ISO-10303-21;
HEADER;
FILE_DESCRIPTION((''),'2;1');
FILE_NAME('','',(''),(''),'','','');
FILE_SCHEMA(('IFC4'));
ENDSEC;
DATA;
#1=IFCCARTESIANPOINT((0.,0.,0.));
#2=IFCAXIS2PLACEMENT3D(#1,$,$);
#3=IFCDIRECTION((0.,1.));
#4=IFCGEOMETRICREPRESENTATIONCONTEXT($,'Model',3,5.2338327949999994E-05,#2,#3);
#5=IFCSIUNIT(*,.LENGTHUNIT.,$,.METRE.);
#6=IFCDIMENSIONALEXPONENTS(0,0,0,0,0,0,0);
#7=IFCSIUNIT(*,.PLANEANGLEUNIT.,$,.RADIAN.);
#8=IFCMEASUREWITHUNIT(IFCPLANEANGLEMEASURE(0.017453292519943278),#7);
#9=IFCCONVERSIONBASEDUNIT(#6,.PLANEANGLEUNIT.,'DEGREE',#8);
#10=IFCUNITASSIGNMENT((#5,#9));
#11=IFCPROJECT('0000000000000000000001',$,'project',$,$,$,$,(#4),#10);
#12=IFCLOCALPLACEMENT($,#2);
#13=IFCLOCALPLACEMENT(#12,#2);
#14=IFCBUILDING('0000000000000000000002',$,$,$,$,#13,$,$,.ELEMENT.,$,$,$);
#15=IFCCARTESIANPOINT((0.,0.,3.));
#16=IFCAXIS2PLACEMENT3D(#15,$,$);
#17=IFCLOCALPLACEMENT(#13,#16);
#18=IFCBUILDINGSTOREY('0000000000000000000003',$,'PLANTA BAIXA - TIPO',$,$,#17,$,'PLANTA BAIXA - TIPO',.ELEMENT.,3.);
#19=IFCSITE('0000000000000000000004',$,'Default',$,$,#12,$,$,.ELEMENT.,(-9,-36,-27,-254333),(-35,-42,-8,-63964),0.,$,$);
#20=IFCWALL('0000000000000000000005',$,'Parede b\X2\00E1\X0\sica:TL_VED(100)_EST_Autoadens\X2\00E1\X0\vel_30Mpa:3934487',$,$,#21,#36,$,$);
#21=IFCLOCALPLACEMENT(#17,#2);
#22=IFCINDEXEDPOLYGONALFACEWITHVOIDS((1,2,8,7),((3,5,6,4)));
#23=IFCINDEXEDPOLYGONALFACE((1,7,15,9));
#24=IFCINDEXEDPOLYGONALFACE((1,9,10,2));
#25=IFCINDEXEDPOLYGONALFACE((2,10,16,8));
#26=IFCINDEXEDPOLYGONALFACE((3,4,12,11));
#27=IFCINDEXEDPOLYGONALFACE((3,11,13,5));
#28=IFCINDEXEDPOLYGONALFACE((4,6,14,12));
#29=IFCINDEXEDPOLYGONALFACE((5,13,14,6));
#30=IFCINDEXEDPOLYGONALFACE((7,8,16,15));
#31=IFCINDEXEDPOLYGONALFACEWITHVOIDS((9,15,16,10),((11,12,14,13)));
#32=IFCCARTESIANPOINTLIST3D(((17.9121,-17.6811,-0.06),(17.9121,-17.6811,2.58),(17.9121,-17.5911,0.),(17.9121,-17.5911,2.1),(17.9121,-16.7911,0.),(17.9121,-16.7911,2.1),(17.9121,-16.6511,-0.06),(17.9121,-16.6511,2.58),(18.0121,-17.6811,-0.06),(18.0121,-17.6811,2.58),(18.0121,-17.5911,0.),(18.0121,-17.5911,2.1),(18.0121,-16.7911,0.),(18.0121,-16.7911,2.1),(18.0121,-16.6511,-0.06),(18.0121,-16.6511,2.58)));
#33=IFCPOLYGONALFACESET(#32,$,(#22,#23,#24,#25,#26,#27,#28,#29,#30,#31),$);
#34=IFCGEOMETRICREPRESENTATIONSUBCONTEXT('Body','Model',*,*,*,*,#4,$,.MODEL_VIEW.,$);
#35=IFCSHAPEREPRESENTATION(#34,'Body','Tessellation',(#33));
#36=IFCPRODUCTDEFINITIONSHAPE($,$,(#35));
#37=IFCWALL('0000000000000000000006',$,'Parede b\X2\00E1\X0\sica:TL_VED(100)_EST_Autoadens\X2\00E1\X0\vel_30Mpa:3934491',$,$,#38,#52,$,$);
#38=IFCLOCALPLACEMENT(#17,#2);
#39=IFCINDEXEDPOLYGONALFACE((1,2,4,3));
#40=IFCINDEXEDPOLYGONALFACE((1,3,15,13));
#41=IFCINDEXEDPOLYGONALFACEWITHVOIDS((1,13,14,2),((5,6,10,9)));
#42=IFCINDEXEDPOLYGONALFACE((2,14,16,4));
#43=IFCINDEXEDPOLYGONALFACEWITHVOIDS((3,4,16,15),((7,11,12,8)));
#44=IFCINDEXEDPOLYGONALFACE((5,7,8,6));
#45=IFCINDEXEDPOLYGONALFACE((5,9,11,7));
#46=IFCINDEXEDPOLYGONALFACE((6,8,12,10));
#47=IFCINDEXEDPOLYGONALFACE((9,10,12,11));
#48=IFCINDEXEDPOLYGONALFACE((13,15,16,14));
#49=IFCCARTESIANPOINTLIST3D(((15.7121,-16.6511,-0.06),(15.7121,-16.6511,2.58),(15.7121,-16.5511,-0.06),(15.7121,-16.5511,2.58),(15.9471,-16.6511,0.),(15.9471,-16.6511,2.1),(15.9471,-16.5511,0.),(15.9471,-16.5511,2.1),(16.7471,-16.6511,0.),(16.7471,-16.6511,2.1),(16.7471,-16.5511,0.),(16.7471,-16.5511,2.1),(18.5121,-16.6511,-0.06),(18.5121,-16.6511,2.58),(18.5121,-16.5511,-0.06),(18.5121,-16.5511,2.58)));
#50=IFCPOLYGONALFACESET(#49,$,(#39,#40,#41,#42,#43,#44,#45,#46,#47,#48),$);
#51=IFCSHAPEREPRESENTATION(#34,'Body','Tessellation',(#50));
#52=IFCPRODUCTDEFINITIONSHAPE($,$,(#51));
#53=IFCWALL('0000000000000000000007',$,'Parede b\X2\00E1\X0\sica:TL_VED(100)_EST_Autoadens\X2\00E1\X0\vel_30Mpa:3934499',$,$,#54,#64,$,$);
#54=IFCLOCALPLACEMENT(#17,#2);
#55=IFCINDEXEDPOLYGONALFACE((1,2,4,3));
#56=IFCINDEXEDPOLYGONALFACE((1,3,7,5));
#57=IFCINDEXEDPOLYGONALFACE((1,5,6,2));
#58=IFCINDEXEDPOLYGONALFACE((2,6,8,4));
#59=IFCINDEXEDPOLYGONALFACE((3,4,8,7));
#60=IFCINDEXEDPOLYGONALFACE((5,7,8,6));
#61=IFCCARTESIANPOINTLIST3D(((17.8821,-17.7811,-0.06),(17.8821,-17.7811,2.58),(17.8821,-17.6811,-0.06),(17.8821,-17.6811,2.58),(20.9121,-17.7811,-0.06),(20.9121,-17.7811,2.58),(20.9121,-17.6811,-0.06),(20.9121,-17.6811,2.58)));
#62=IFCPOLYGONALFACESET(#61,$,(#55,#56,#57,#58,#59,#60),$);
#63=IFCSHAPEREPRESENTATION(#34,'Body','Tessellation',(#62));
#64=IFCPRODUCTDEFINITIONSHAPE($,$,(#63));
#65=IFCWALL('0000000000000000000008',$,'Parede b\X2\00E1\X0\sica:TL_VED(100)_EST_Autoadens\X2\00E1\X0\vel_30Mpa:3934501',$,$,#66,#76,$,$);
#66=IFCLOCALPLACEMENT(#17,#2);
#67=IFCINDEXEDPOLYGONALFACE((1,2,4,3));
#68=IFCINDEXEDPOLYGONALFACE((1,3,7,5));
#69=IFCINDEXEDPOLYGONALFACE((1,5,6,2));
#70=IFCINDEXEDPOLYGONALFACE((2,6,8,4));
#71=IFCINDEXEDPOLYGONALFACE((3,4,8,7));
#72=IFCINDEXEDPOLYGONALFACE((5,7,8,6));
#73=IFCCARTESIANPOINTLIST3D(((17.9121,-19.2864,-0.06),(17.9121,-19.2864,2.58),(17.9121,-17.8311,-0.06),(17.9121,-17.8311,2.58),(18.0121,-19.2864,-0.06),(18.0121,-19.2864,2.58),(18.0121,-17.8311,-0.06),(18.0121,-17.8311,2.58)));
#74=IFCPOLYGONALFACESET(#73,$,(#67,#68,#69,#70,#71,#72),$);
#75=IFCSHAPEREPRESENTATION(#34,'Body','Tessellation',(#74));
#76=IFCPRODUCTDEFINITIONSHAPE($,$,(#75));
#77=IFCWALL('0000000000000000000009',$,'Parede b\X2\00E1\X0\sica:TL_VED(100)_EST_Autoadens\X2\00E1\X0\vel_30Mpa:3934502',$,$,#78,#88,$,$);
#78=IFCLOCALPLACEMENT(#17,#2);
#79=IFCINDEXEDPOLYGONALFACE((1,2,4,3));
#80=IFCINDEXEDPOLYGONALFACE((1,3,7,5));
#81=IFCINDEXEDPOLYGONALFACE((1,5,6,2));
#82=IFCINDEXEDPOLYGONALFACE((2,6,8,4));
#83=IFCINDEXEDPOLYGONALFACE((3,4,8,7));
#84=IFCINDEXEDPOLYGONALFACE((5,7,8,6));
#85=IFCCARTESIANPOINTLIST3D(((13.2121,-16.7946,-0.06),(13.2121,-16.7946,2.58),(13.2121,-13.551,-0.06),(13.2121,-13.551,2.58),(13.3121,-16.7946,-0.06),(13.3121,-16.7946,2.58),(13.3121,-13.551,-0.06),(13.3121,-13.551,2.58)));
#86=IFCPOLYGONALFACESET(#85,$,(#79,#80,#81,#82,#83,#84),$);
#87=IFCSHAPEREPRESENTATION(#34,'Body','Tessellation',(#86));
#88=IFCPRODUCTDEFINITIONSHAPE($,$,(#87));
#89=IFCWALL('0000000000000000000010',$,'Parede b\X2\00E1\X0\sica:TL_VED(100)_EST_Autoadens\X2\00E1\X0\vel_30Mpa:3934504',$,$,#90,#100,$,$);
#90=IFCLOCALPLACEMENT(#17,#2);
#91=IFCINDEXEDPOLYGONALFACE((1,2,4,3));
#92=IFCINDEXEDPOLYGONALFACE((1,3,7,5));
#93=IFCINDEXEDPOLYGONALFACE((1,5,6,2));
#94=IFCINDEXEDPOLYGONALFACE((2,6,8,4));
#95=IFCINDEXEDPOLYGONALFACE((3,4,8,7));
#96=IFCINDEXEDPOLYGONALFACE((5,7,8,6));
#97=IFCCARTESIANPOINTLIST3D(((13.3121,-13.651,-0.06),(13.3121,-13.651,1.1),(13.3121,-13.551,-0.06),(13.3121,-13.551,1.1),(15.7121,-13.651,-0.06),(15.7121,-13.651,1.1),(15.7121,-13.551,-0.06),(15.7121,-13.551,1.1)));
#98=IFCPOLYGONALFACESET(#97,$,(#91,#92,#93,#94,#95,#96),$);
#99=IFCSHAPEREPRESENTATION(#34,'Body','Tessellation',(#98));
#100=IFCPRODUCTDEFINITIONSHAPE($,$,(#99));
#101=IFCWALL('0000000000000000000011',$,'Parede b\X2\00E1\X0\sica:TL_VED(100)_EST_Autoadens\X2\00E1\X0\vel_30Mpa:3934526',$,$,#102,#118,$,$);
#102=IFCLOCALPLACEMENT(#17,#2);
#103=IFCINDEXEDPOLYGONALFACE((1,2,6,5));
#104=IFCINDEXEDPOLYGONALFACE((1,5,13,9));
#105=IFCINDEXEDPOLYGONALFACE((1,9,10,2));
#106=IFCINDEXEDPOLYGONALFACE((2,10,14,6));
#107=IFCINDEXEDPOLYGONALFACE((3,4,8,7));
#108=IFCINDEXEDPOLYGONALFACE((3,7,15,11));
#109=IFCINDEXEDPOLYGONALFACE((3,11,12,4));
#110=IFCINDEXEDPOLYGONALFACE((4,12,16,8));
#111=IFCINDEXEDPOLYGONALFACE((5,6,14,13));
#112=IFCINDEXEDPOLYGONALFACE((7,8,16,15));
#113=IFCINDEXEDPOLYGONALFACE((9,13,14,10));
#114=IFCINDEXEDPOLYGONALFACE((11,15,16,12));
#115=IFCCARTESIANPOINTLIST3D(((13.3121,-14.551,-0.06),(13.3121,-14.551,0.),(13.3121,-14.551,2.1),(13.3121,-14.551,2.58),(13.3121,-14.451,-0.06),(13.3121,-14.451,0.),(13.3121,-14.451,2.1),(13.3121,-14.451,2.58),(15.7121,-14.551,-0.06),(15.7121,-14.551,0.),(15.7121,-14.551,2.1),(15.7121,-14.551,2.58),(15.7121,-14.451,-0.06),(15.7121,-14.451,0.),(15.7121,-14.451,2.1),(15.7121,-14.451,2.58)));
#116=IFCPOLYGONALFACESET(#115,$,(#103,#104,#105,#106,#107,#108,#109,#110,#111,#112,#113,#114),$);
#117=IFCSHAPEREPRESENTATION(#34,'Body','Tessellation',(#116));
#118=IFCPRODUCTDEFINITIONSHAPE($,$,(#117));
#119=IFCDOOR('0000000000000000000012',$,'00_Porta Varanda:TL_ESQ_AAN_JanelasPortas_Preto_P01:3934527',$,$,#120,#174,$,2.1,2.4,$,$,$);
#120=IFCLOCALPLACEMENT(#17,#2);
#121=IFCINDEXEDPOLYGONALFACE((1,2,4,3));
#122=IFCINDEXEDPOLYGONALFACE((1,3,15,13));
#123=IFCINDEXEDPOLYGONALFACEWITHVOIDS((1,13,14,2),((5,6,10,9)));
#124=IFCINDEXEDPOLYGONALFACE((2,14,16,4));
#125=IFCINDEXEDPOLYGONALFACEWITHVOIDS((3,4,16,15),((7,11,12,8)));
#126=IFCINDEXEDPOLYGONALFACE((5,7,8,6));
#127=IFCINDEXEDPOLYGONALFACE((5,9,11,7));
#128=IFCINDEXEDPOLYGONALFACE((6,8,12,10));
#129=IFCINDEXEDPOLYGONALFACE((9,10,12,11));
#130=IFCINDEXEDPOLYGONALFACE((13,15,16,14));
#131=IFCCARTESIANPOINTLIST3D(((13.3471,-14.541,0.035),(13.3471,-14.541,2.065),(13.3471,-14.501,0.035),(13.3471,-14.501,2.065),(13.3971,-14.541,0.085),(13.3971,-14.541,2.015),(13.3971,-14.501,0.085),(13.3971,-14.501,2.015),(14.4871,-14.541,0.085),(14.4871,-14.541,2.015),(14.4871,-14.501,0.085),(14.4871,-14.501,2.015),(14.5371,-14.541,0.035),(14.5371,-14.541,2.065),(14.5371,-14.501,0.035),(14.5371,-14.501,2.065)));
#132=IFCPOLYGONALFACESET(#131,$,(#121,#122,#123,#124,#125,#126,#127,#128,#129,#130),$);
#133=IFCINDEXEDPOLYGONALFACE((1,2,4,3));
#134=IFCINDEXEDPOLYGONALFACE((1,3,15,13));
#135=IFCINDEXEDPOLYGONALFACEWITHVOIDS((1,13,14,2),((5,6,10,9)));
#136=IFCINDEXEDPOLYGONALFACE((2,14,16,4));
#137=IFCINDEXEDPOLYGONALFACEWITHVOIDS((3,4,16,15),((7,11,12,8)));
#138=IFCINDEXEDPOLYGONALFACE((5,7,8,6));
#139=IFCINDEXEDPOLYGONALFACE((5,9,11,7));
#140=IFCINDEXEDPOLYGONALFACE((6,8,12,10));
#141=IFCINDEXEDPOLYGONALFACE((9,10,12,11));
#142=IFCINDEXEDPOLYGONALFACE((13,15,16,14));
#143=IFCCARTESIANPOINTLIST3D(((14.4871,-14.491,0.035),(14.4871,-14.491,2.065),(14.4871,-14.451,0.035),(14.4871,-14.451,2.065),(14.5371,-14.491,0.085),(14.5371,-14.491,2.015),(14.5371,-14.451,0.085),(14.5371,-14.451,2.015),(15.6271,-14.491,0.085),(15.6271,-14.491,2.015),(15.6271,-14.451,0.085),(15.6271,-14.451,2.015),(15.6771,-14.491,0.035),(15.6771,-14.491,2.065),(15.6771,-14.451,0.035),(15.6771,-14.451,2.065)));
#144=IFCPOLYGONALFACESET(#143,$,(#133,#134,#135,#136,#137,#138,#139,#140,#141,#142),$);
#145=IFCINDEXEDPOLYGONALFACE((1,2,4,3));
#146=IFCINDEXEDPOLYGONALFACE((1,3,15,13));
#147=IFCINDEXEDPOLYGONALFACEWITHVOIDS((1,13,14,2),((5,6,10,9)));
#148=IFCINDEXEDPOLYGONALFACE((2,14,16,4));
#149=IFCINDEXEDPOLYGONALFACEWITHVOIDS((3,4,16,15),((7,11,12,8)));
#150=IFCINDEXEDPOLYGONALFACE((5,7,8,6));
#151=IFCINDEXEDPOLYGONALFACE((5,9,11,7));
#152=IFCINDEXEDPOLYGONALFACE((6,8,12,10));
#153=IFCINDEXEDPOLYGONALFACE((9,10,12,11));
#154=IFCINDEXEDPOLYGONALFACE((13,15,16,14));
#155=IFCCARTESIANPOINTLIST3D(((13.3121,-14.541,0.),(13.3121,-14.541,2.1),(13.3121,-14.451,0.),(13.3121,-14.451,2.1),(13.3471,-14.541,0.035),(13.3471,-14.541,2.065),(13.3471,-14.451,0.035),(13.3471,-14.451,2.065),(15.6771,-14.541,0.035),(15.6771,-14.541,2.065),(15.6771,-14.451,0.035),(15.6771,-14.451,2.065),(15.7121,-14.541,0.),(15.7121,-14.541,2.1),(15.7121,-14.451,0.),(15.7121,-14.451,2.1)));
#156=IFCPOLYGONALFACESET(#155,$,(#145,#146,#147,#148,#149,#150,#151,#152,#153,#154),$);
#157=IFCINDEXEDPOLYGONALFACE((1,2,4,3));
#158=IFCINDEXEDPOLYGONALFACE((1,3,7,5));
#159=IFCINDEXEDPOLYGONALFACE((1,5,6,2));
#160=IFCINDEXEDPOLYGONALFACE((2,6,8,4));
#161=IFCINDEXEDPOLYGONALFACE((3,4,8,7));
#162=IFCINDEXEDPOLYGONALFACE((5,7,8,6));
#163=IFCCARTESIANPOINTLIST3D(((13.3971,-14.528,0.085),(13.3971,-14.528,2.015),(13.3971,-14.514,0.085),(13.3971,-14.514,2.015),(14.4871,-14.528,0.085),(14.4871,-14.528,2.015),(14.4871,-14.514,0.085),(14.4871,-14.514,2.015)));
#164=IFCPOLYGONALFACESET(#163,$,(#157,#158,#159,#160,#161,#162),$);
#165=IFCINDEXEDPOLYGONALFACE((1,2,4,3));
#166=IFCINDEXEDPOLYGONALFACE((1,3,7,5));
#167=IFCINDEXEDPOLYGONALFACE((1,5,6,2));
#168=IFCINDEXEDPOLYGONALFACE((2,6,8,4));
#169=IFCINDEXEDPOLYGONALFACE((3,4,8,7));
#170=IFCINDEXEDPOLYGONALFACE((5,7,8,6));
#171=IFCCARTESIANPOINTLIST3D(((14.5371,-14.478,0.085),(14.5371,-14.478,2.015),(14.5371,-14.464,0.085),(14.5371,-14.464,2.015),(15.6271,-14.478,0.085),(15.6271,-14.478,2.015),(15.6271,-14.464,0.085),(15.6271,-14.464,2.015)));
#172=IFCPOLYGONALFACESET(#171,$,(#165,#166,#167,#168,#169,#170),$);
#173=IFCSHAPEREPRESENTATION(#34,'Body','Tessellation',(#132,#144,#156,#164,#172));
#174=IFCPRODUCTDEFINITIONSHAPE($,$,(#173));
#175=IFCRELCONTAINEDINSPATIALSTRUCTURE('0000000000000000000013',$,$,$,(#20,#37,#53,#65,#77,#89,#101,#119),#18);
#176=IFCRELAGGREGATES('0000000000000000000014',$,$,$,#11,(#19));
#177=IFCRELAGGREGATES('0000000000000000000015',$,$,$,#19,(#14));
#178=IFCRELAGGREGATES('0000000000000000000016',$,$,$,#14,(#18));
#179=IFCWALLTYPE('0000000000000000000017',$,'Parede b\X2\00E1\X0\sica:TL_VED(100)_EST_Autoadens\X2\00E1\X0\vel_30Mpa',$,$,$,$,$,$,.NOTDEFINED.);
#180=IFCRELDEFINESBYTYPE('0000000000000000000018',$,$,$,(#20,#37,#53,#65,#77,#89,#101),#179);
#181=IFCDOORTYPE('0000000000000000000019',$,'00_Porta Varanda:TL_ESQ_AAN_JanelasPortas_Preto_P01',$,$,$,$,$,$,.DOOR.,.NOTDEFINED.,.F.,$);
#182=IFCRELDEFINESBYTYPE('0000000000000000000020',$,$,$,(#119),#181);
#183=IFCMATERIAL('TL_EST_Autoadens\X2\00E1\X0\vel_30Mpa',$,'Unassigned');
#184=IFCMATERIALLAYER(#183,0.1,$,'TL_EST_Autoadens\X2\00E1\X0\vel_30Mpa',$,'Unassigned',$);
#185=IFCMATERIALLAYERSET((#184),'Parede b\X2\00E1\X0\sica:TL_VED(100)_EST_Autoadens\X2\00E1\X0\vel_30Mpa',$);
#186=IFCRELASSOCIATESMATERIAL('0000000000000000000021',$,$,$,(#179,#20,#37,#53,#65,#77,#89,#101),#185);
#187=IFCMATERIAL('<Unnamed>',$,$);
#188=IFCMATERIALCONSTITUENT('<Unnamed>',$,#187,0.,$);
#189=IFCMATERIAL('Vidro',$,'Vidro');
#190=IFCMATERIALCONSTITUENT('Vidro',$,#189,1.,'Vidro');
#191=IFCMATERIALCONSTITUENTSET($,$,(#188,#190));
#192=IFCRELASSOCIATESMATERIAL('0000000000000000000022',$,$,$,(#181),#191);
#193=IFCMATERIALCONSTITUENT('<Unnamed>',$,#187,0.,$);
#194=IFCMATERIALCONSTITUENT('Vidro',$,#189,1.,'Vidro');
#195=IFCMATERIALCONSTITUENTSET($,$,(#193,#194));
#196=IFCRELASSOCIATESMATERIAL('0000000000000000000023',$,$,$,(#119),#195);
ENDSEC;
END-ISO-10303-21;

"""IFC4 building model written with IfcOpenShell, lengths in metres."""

from ifc_helpers import new_model, entity, si_unit, converted_unit, direction, frame, frame_2d, origin, place, context, subcontext, project, spatial, polyline, rectangle, outline, extrude, source, transform, mapped, material, layer, layer_set, layer_usage, constituent, constituent_set, type_object, type_shapes, element, fill, save


model = new_model("IFC4")

# Units and contexts
model_context = context("Model", 3, precision=5.2338327949999994e-05, world=origin(), true_north=direction((0.0, 1.0)))
body_context = subcontext(model_context, "Body", "Model", "MODEL_VIEW")
ifc_project = project(units=[si_unit("LENGTHUNIT", "METRE"), converted_unit("PLANEANGLEUNIT", "DEGREE", entity("IfcPlaneAngleMeasure", 0.017453292519943278), si_unit("PLANEANGLEUNIT", "RADIAN"), dimensions=[0, 0, 0, 0, 0, 0, 0])], contexts=[model_context])

# Site, building, storey
site_placement = place(None, frame((0.0, 0.0, 0.0)))
site = spatial("IfcSite", under=ifc_project, at=site_placement, Name="Default", CompositionType="ELEMENT", RefLatitude=(-9, -36, -27, -254333), RefLongitude=(-35, -42, -8, -63964), RefElevation=0.0)
building_placement = place(site_placement, origin())
building = spatial("IfcBuilding", under=site, at=building_placement, CompositionType="ELEMENT")
storey_placement = place(building_placement, frame((0.0, 0.0, 3.0)))
storey = spatial("IfcBuildingStorey", under=building, at=storey_placement, Name="PLANTA BAIXA - TIPO", LongName="PLANTA BAIXA - TIPO", CompositionType="ELEMENT", Elevation=3.0)

# Walls, openings
ifc_material_1 = material(Name="TL_EST_Autoadensável_30Mpa", Category="Unassigned")
ifc_layer_1 = layer(ifc_material_1, 0.1, Name="TL_EST_Autoadensável_30Mpa", Category="Unassigned")
ifc_layer_set_1 = layer_set([ifc_layer_1], Name="Parede básica:TL_VED(100)_EST_Autoadensável_30Mpa")
ifc_layer_usage_1 = layer_usage(ifc_layer_set_1, "AXIS2", "NEGATIVE", 0.05)
wall_type_1 = type_object("IfcWallType", Name="Parede básica:TL_VED(100)_EST_Autoadensável_30Mpa", PredefinedType="NOTDEFINED", material=ifc_layer_set_1)
wall_1_placement = place(storey_placement, frame((17.9621, -16.6511, -0.06), z_axis=(0.0, 0.0, 1.0), x_axis=(0.0, -1.0, 0.0)))
wall_1 = element("IfcWall", 1, at=wall_1_placement, inside=storey, type_object=wall_type_1, material=ifc_layer_usage_1, Name="Parede básica:TL_VED(100)_EST_Autoadensável_30Mpa:3934487", context=body_context, shape_type="SweptSolid", body=[
    extrude(rectangle(XDim=1.03, YDim=0.1, at=frame_2d((0.515, 0.0), x_axis=(-1.0, 0.0))), origin(), (0.0, 0.0, 1.0), 2.64),
])
opening_1_placement = place(wall_1_placement, frame((0.14, -0.05, 0.06)))
element("IfcOpeningElement", 2, at=opening_1_placement, cuts=wall_1, PredefinedType="OPENING", context=body_context, shape_type="SweptSolid", body=[
    extrude(rectangle(XDim=2.1, YDim=0.8, at=frame_2d((1.05, 0.4), x_axis=(1.0, 0.0))), frame((0.0, 0.0, 0.0), z_axis=(0.0, 1.0, 0.0), x_axis=(0.0, 0.0, 1.0)), (0.0, 0.0, 1.0), 0.1),
])
ifc_layer_usage_2 = layer_usage(ifc_layer_set_1, "AXIS2", "NEGATIVE", 0.05)
wall_2_placement = place(storey_placement, frame((15.7121, -16.6011, -0.06)))
wall_2 = element("IfcWall", 3, at=wall_2_placement, inside=storey, type_object=wall_type_1, material=ifc_layer_usage_2, Name="Parede básica:TL_VED(100)_EST_Autoadensável_30Mpa:3934491", context=body_context, shape_type="SweptSolid", body=[
    extrude(rectangle(XDim=2.8, YDim=0.1, at=frame_2d((1.4, 0.0), x_axis=(-1.0, 0.0))), origin(), (0.0, 0.0, 1.0), 2.64),
])
opening_2_placement = place(wall_2_placement, frame((0.235, -0.05, 0.06)))
element("IfcOpeningElement", 4, at=opening_2_placement, cuts=wall_2, PredefinedType="OPENING", context=body_context, shape_type="SweptSolid", body=[
    extrude(rectangle(XDim=2.1, YDim=0.8, at=frame_2d((1.05, 0.4), x_axis=(1.0, 0.0))), frame((0.0, 0.0, 0.0), z_axis=(0.0, 1.0, 0.0), x_axis=(0.0, 0.0, 1.0)), (0.0, 0.0, 1.0), 0.1),
])

# Walls
ifc_layer_usage_3 = layer_usage(ifc_layer_set_1, "AXIS2", "POSITIVE", -0.05)
wall_3_placement = place(storey_placement, frame((17.8821, -17.7311, -0.06)))
element("IfcWall", 5, at=wall_3_placement, inside=storey, type_object=wall_type_1, material=ifc_layer_usage_3, Name="Parede básica:TL_VED(100)_EST_Autoadensável_30Mpa:3934499", context=body_context, shape_type="SweptSolid", body=[
    extrude(rectangle(XDim=3.03, YDim=0.1, at=frame_2d((1.515, 0.0), x_axis=(-1.0, 0.0))), origin(), (0.0, 0.0, 1.0), 2.64),
])
ifc_layer_usage_4 = layer_usage(ifc_layer_set_1, "AXIS2", "NEGATIVE", 0.05)
wall_4_placement = place(storey_placement, frame((17.9621, -19.2864, -0.06), z_axis=(0.0, 0.0, 1.0), x_axis=(0.0, 1.0, 0.0)))
element("IfcWall", 6, at=wall_4_placement, inside=storey, type_object=wall_type_1, material=ifc_layer_usage_4, Name="Parede básica:TL_VED(100)_EST_Autoadensável_30Mpa:3934501", context=body_context, shape_type="SweptSolid", body=[
    extrude(rectangle(XDim=1.4552, YDim=0.1, at=frame_2d((0.7276, 0.0), x_axis=(-1.0, 0.0))), origin(), (0.0, 0.0, 1.0), 2.64),
])
ifc_layer_usage_5 = layer_usage(ifc_layer_set_1, "AXIS2", "POSITIVE", -0.05)
wall_5_placement = place(storey_placement, frame((13.2621, -13.551, -0.06), z_axis=(0.0, 0.0, 1.0), x_axis=(0.0, -1.0, 0.0)))
element("IfcWall", 7, at=wall_5_placement, inside=storey, type_object=wall_type_1, material=ifc_layer_usage_5, Name="Parede básica:TL_VED(100)_EST_Autoadensável_30Mpa:3934502", context=body_context, shape_type="SweptSolid", body=[
    extrude(rectangle(XDim=3.2437, YDim=0.1, at=frame_2d((1.6218, 0.0), x_axis=(-1.0, 0.0))), origin(), (0.0, 0.0, 1.0), 2.64),
])

# Wall
ifc_layer_usage_6 = layer_usage(ifc_layer_set_1, "AXIS2", "POSITIVE", -0.05)
wall_6_placement = place(storey_placement, frame((15.7121, -13.601, -0.06), z_axis=(0.0, 0.0, 1.0), x_axis=(-1.0, 0.0, 0.0)))
element("IfcWall", 8, at=wall_6_placement, inside=storey, type_object=wall_type_1, material=ifc_layer_usage_6, Name="Parede básica:TL_VED(100)_EST_Autoadensável_30Mpa:3934504", context=body_context, shape_type="SweptSolid", body=[
    extrude(rectangle(XDim=2.4, YDim=0.1, at=frame_2d((1.2, 0.0), x_axis=(-1.0, 0.0))), origin(), (0.0, 0.0, 1.0), 1.16),
])

# Wall, opening, door
ifc_layer_usage_7 = layer_usage(ifc_layer_set_1, "AXIS2", "POSITIVE", -0.05)
wall_7_placement = place(storey_placement, frame((15.7121, -14.501, -0.06), z_axis=(0.0, 0.0, 1.0), x_axis=(-1.0, 0.0, 0.0)))
wall_7 = element("IfcWall", 9, at=wall_7_placement, inside=storey, type_object=wall_type_1, material=ifc_layer_usage_7, Name="Parede básica:TL_VED(100)_EST_Autoadensável_30Mpa:3934526", context=body_context, shape_type="SweptSolid", body=[
    extrude(rectangle(XDim=2.4, YDim=0.1, at=frame_2d((1.2, 0.0), x_axis=(-1.0, 0.0))), origin(), (0.0, 0.0, 1.0), 2.64),
])
opening_3_placement = place(wall_7_placement, frame((0.0, -0.05, 0.06)))
opening_3 = element("IfcOpeningElement", 10, at=opening_3_placement, cuts=wall_7, PredefinedType="OPENING", context=body_context, shape_type="SweptSolid", body=[
    extrude(rectangle(XDim=2.1, YDim=2.4, at=frame_2d((1.05, 1.2), x_axis=(1.0, 0.0))), frame((0.0, 0.0, 0.0), z_axis=(0.0, 1.0, 0.0), x_axis=(0.0, 0.0, 1.0)), (0.0, 0.0, 1.0), 0.1),
])
ifc_material_2 = material(Name="<Unnamed>")
ifc_constituent_1 = constituent(ifc_material_2, Name="<Unnamed>", fraction=0.0)
ifc_material_3 = material(Name="Vidro", Category="Vidro")
ifc_constituent_2 = constituent(ifc_material_3, Name="Vidro", Category="Vidro", fraction=1.0)
ifc_constituent_set_1 = constituent_set(constituents=[ifc_constituent_1, ifc_constituent_2])
ifc_constituent_3 = constituent(ifc_material_2, Name="<Unnamed>", fraction=0.0)
ifc_constituent_4 = constituent(ifc_material_3, Name="Vidro", Category="Vidro", fraction=1.0)
ifc_constituent_set_2 = constituent_set(constituents=[ifc_constituent_3, ifc_constituent_4])
door_type = type_object("IfcDoorType", Name="00_Porta Varanda:TL_ESQ_AAN_JanelasPortas_Preto_P01", OperationType="NOTDEFINED", ParameterTakesPrecedence=False, PredefinedType="DOOR", material=ifc_constituent_set_2)
shared_shape = source(origin(), body_context, "Body", "SweptSolid", [
    extrude(outline(polyline([(-1.015, -0.595), (1.015, -0.595), (1.015, 0.595), (-1.015, 0.595), (-1.015, -0.595)]), holes=[polyline([(0.965, -0.545), (-0.965, -0.545), (-0.965, 0.545), (0.965, 0.545), (0.965, -0.545)])]), frame((1.77, 0.05, 1.05), z_axis=(0.0, 1.0, 0.0), x_axis=(0.0, 0.0, 1.0)), (0.0, 0.0, 1.0), 0.04),
    extrude(outline(polyline([(-1.015, -0.595), (1.015, -0.595), (1.015, 0.595), (-1.015, 0.595), (-1.015, -0.595)]), holes=[polyline([(0.965, -0.545), (-0.965, -0.545), (-0.965, 0.545), (0.965, 0.545), (0.965, -0.545)])]), frame((0.63, 0.0, 1.05), z_axis=(0.0, 1.0, 0.0), x_axis=(0.0, 0.0, -1.0)), (0.0, 0.0, 1.0), 0.04),
    extrude(outline(polyline([(-1.05, -1.2), (1.05, -1.2), (1.05, 1.2), (-1.05, 1.2), (-1.05, -1.2)]), holes=[polyline([(1.015, -1.165), (-1.015, -1.165), (-1.015, 1.165), (1.015, 1.165), (1.015, -1.165)])]), frame((1.2, 0.0, 1.05), z_axis=(0.0, 1.0, 0.0), x_axis=(0.0, 0.0, -1.0)), (0.0, 0.0, 1.0), 0.09),
    extrude(rectangle(XDim=0.014, YDim=1.09, at=frame_2d((0.0, 0.0), x_axis=(1.0, 0.0))), frame((1.77, 0.07, 0.085), z_axis=(0.0, 0.0, 1.0), x_axis=(0.0, -1.0, 0.0)), (0.0, 0.0, 1.0), 1.93),
    extrude(rectangle(XDim=0.014, YDim=1.09, at=frame_2d((0.0, 0.0), x_axis=(1.0, 0.0))), frame((0.63, 0.02, 0.085), z_axis=(0.0, 0.0, 1.0), x_axis=(0.0, -1.0, 0.0)), (0.0, 0.0, 1.0), 1.93),
])
type_shapes(door_type, [shared_shape])
door_placement = place(opening_3_placement, origin())
door = element("IfcDoor", 11, at=door_placement, inside=storey, type_object=door_type, material=ifc_constituent_set_1, Name="00_Porta Varanda:TL_ESQ_AAN_JanelasPortas_Preto_P01:3934527", OverallHeight=2.1, OverallWidth=2.4, context=body_context, shape_type="MappedRepresentation", body=[
    mapped(shared_shape, transform((0.0, 0.0, 0.0), scale=1.0)),
])
fill(opening_3, door)

save(model, "model.ifc")
